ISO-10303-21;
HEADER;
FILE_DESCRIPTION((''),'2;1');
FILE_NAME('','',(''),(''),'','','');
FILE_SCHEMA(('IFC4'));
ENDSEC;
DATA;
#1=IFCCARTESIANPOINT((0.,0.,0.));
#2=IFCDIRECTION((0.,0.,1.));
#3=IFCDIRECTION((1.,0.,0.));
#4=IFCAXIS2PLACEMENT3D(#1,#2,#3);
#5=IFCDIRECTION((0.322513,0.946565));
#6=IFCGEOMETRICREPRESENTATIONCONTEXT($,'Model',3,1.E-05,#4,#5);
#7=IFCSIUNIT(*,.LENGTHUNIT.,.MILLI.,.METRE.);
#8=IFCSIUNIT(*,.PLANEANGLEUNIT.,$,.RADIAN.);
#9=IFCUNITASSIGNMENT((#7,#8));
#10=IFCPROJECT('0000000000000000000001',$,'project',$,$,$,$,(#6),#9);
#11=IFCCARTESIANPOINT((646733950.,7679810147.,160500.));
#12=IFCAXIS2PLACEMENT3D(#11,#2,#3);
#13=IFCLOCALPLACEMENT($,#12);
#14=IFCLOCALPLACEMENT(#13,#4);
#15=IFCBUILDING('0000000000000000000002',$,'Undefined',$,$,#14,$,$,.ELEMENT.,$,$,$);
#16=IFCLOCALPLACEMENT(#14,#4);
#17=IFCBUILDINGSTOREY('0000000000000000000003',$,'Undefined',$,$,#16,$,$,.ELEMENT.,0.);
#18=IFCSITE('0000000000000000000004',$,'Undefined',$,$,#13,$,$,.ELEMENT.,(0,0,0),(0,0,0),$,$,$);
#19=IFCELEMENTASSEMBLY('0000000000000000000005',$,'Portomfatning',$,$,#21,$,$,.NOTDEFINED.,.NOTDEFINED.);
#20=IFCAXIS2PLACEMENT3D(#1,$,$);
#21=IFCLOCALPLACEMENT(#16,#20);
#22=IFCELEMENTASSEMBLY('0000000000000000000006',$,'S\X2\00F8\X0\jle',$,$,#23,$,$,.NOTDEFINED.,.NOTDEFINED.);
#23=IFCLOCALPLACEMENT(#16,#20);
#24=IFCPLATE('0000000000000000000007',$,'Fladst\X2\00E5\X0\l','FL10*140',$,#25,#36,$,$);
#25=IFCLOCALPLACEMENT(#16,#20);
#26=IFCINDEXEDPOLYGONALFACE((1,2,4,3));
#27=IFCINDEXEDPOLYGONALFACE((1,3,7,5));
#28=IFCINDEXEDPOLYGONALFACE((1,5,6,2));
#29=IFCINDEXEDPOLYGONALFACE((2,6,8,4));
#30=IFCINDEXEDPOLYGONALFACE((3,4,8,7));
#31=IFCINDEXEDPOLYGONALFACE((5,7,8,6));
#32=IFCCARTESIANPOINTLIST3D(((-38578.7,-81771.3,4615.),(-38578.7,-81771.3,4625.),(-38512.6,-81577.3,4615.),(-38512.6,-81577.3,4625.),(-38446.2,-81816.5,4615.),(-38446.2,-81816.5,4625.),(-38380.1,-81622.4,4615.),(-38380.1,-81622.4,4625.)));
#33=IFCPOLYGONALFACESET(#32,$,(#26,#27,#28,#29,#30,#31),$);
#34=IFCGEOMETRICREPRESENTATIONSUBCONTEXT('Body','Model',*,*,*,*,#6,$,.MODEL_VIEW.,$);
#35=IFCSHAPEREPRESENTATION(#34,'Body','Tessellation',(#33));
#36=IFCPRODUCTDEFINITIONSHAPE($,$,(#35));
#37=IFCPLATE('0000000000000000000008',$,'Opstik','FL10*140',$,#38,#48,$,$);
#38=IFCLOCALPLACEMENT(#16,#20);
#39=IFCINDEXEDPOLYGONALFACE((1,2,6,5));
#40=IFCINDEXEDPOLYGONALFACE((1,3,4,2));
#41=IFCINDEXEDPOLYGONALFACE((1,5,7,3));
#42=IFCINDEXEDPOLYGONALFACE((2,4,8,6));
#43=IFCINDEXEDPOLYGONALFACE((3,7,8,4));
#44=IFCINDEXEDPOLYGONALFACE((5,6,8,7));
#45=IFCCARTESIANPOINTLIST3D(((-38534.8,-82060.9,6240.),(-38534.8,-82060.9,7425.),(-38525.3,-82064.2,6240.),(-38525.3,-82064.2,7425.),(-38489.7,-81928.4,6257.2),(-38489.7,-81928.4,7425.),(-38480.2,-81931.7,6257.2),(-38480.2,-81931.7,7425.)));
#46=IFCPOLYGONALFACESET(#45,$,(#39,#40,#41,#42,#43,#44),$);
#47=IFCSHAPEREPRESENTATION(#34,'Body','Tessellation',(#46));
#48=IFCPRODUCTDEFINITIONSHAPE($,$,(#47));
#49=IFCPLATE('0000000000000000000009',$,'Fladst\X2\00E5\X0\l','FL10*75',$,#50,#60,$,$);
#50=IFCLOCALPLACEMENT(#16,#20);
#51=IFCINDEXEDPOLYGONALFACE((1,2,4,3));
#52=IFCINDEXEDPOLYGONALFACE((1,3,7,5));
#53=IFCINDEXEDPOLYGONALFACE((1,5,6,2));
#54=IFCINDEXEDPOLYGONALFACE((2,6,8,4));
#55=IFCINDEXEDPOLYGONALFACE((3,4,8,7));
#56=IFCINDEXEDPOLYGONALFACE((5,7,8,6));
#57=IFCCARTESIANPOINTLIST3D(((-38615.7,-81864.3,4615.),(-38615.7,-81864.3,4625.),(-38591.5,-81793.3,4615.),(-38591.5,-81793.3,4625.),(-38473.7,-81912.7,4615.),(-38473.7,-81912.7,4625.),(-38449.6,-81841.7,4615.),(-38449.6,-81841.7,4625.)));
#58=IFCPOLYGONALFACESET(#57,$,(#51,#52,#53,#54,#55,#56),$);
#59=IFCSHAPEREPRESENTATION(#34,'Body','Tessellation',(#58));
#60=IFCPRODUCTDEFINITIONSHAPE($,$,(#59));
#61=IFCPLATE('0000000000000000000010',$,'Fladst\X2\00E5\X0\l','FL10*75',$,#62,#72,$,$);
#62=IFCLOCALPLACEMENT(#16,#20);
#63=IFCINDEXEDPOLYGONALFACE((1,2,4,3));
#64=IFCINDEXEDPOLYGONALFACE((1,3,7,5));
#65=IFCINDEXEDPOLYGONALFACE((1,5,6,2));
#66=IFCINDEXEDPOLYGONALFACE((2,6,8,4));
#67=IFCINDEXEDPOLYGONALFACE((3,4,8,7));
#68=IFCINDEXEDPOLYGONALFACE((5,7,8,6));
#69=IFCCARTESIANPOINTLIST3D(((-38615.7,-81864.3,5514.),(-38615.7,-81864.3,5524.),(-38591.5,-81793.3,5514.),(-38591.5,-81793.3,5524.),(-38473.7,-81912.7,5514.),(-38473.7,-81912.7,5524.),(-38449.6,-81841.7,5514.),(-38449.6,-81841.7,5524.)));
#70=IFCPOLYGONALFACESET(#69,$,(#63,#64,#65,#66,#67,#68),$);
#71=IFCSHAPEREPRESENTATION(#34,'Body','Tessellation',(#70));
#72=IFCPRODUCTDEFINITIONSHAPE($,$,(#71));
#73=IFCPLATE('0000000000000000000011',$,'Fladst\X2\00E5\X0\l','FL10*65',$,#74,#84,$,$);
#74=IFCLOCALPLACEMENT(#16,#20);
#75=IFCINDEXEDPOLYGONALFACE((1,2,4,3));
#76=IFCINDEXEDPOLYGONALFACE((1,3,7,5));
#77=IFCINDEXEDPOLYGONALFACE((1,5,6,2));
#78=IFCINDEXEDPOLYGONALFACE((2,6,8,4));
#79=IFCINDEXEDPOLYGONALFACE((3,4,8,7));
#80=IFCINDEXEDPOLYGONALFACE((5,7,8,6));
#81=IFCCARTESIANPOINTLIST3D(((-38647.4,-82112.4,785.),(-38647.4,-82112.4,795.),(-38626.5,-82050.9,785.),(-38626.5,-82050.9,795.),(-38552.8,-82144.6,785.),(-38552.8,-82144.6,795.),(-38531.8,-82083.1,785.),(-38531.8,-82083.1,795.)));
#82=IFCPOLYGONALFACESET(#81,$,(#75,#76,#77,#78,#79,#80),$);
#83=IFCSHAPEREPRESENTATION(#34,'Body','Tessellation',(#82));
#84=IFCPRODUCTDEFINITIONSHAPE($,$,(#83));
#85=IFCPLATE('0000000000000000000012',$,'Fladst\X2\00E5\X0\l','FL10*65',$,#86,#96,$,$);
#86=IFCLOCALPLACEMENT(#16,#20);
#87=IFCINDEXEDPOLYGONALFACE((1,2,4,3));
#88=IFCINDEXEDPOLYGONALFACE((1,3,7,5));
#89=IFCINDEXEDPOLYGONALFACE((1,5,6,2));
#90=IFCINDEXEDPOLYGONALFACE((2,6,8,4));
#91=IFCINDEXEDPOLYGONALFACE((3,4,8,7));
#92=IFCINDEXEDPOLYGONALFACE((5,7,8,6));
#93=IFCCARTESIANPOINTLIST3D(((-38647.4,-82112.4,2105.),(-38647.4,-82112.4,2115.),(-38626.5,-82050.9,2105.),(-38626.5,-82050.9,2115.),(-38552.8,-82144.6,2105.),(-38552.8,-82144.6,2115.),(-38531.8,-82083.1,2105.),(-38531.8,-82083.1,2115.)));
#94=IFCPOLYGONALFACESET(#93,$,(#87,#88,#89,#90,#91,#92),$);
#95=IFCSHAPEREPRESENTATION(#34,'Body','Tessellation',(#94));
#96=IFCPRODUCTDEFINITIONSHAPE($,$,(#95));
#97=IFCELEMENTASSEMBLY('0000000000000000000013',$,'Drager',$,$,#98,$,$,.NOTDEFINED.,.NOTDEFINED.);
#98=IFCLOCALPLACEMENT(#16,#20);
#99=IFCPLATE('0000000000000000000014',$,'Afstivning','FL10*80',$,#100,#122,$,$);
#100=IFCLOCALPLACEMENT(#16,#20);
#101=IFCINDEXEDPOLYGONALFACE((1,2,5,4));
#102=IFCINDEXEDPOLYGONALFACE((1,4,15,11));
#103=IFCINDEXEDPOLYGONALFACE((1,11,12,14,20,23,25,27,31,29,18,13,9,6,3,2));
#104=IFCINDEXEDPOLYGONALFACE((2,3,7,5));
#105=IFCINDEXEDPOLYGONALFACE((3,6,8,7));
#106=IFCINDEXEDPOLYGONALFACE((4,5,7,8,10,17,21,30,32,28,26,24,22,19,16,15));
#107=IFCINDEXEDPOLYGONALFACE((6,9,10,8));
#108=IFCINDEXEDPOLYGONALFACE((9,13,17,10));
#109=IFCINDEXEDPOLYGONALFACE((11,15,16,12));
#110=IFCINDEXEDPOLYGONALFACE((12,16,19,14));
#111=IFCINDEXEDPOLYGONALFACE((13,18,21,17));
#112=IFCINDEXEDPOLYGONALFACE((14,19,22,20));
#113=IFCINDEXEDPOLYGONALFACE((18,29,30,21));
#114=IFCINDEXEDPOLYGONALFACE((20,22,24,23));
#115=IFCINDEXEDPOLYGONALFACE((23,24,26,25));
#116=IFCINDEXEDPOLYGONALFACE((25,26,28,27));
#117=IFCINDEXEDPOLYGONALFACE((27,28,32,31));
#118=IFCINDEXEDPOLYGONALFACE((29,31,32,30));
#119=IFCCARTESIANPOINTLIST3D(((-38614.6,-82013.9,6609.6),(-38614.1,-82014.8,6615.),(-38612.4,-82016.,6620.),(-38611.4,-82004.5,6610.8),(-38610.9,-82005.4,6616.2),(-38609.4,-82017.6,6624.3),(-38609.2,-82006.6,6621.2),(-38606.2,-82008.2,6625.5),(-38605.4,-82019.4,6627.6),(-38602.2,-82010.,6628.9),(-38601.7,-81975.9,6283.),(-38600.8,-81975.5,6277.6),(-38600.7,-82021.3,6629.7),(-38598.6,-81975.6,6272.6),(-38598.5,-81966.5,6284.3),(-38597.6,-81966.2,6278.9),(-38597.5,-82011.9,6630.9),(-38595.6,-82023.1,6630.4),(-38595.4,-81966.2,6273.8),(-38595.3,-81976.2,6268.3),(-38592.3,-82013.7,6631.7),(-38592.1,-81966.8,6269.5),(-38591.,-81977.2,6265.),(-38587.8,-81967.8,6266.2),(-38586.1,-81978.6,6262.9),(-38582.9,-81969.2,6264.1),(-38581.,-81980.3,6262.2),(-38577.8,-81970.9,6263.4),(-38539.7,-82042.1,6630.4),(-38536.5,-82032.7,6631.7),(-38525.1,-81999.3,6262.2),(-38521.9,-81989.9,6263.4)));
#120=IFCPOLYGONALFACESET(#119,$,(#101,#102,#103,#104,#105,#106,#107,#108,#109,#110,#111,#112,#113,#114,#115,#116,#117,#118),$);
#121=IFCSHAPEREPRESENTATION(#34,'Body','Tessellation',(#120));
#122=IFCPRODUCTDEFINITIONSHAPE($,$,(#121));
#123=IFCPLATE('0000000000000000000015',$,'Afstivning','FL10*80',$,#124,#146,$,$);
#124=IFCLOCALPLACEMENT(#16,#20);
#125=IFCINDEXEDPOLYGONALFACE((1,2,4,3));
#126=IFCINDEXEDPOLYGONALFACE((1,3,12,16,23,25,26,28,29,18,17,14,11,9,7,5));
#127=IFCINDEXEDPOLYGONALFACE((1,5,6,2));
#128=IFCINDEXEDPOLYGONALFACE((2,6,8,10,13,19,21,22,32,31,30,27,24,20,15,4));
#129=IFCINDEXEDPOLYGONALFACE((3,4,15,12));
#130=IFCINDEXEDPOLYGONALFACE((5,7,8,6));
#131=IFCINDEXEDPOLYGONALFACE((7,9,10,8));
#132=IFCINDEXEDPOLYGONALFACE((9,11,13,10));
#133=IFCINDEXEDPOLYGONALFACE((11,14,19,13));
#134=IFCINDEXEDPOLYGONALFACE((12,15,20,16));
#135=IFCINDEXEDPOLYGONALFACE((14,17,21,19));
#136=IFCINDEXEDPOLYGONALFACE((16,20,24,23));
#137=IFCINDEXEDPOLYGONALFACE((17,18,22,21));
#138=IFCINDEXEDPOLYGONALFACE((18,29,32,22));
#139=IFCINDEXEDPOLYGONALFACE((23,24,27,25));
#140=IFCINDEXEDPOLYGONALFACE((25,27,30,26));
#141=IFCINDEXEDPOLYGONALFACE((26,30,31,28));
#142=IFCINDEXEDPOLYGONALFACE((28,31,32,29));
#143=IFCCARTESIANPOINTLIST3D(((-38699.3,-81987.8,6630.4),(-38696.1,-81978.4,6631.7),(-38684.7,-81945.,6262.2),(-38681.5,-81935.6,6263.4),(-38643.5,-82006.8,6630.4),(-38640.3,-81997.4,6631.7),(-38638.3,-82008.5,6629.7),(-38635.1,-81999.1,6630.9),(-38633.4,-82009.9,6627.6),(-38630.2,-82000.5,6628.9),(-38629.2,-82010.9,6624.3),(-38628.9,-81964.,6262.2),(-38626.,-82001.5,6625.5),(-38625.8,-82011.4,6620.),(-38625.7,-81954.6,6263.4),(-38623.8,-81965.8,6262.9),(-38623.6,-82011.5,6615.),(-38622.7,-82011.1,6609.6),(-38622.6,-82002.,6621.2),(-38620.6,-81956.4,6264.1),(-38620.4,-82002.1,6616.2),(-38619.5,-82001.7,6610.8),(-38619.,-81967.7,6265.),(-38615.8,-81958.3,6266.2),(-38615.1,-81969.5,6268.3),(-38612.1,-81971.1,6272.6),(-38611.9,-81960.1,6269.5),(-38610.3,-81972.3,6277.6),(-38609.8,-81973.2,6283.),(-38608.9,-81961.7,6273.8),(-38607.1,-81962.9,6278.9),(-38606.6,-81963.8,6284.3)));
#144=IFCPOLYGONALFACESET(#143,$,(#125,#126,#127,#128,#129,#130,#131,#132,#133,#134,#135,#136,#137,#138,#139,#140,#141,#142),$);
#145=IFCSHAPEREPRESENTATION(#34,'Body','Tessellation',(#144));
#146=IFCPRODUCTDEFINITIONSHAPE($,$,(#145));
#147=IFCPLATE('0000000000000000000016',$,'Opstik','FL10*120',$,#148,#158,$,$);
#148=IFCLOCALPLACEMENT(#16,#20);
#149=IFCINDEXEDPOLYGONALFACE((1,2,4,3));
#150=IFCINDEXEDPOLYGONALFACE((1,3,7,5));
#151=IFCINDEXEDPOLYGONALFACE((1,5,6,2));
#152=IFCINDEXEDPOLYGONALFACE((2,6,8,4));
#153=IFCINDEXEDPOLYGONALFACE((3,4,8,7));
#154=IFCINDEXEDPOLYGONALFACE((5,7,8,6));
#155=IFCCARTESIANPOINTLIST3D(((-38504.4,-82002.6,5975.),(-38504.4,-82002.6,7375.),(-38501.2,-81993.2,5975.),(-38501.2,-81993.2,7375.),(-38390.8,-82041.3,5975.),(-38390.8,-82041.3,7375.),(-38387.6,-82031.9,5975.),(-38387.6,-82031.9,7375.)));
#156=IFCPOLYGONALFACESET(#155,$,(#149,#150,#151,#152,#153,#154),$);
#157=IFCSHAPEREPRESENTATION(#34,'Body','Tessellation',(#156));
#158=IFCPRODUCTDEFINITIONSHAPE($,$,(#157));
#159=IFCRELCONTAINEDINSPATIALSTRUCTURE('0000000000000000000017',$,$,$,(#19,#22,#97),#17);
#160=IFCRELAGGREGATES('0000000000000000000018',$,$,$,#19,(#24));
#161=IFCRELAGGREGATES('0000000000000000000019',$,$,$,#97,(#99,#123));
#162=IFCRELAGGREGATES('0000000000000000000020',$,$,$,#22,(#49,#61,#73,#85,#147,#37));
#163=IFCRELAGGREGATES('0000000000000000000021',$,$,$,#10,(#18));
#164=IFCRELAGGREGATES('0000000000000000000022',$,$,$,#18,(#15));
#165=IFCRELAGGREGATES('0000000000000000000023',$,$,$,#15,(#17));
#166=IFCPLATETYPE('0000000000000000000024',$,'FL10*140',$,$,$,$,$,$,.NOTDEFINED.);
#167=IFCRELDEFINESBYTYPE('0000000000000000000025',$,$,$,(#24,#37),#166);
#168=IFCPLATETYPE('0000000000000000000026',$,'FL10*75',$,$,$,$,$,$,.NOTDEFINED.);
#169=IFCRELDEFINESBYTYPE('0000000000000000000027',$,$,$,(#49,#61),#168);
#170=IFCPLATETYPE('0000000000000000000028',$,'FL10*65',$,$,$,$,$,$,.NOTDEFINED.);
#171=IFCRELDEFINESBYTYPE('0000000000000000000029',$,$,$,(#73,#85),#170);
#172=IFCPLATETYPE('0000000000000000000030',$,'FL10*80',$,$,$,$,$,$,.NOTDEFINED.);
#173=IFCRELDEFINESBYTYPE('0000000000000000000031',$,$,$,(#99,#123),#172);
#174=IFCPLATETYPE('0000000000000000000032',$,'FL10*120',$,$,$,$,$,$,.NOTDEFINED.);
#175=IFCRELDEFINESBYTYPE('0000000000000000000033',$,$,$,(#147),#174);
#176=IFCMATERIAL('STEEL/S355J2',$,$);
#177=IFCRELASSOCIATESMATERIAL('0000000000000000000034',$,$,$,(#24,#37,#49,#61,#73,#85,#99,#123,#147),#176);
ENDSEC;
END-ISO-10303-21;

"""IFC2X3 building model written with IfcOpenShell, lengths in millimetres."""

from ifc_helpers import new_model, si_unit, direction, frame, frame_2d, origin_with_axes, place, context, subcontext, project, spatial, polyline, circle_curve, parameter, trimmed, segment, composite_curve, outline, extrude, material, type_object, element, aggregate, save


model = new_model("IFC2X3")

# Units and contexts
model_context = context("Model", 3, precision=1e-05, world=origin_with_axes(), true_north=direction((0.322513, 0.946565)))
body_context = subcontext(model_context, "Body", "Model", "MODEL_VIEW")
ifc_project = project(units=[si_unit("LENGTHUNIT", "METRE", prefix="MILLI"), si_unit("PLANEANGLEUNIT", "RADIAN")], contexts=[model_context])

# Site, building, storey
site_placement = place(None, frame((646733950.0, 7679810147.0, 160500.0), z_axis=(0.0, 0.0, 1.0), x_axis=(1.0, 0.0, 0.0)))
site = spatial("IfcSite", under=ifc_project, at=site_placement, Name="Undefined", CompositionType="ELEMENT", RefLatitude=(0, 0, 0), RefLongitude=(0, 0, 0))
building_placement = place(site_placement, origin_with_axes())
building = spatial("IfcBuilding", under=site, at=building_placement, Name="Undefined", CompositionType="ELEMENT")
storey_placement = place(building_placement, origin_with_axes())
storey = spatial("IfcBuildingStorey", under=building, at=storey_placement, Name="Undefined", CompositionType="ELEMENT", Elevation=0.0)

# Element assemblies
assembly_1_placement = place(storey_placement, origin_with_axes())
assembly_1 = element("IfcElementAssembly", 1, at=assembly_1_placement, inside=storey, Name="Portomfatning", AssemblyPlace="NOTDEFINED", PredefinedType="NOTDEFINED")
assembly_2_placement = place(storey_placement, origin_with_axes())
assembly_2 = element("IfcElementAssembly", 2, at=assembly_2_placement, inside=storey, Name="Søjle", AssemblyPlace="NOTDEFINED", PredefinedType="NOTDEFINED")

# Shared definitions
ifc_material_1 = material(Name="STEEL/S355J2")

# Plates
plate_type_1 = type_object("IfcPlateType", Name="FL10*140", PredefinedType="NOTDEFINED")
plate_1_placement = place(assembly_1_placement, frame((-38446.4, -81599.8, 4620.0), z_axis=(0.0, 0.0, -1.0), x_axis=(-0.322513, -0.946565, 0.0)))
plate_1 = element("IfcPlate", 3, at=plate_1_placement, type_object=plate_type_1, material=ifc_material_1, Name="Fladstål", Description="FL10*140", context=body_context, shape_type="SweptSolid", body=[
    extrude(outline(polyline([(0.0, -70.0), (0.0, 70.0), (205.0, 70.0), (205.0, -70.0), (0.0, -70.0)])), frame((0.0, 0.0, -5.0), z_axis=(0.0, 0.0, 1.0), x_axis=(1.0, 0.0, 0.0)), (0.0, 0.0, 1.0), 10.0),
])
plate_2_placement = place(assembly_2_placement, frame((-38484.9, -81930.0, 6257.2), z_axis=(0.946565, -0.322513, 0.0), x_axis=(0.0, 0.0, 1.0)))
plate_2 = element("IfcPlate", 4, at=plate_2_placement, type_object=plate_type_1, material=ifc_material_1, Name="Opstik", Description="FL10*140", context=body_context, shape_type="SweptSolid", body=[
    extrude(outline(polyline([(0.0, 0.0), (1167.8, 0.0), (1167.8, 0.0), (1167.8, 140.0), (1167.8, 140.0), (-17.2, 140.0), (0.0, 0.0)])), frame((0.0, 0.0, -5.0), z_axis=(0.0, 0.0, 1.0), x_axis=(1.0, 0.0, 0.0)), (0.0, 0.0, 1.0), 10.0),
])
plate_type_2 = type_object("IfcPlateType", Name="FL10*75", PredefinedType="NOTDEFINED")
plate_3_placement = place(assembly_2_placement, frame((-38615.7, -81864.3, 4620.0), z_axis=(0.0, 0.0, -1.0), x_axis=(0.322513, 0.946565, 0.0)))
plate_3 = element("IfcPlate", 5, at=plate_3_placement, type_object=plate_type_2, material=ifc_material_1, Name="Fladstål", Description="FL10*75", context=body_context, shape_type="SweptSolid", body=[
    extrude(outline(polyline([(0.0, 0.0), (75.0, 0.0), (75.0, 150.0), (0.0, 150.0), (0.0, 0.0)])), frame((0.0, 0.0, -5.0), z_axis=(0.0, 0.0, 1.0), x_axis=(1.0, 0.0, 0.0)), (0.0, 0.0, 1.0), 10.0),
])
plate_4_placement = place(assembly_2_placement, frame((-38615.7, -81864.3, 5519.0), z_axis=(0.0, 0.0, -1.0), x_axis=(0.322513, 0.946565, 0.0)))
plate_4 = element("IfcPlate", 6, at=plate_4_placement, type_object=plate_type_2, material=ifc_material_1, Name="Fladstål", Description="FL10*75", context=body_context, shape_type="SweptSolid", body=[
    extrude(outline(polyline([(0.0, 0.0), (75.0, 0.0), (75.0, 150.0), (0.0, 150.0), (0.0, 0.0)])), frame((0.0, 0.0, -5.0), z_axis=(0.0, 0.0, 1.0), x_axis=(1.0, 0.0, 0.0)), (0.0, 0.0, 1.0), 10.0),
])
plate_type_3 = type_object("IfcPlateType", Name="FL10*65", PredefinedType="NOTDEFINED")
plate_5_placement = place(assembly_2_placement, frame((-38626.5, -82050.9, 790.0), z_axis=(0.0, 0.0, 1.0), x_axis=(-0.322513, -0.946565, 0.0)))
plate_5 = element("IfcPlate", 7, at=plate_5_placement, type_object=plate_type_3, material=ifc_material_1, Name="Fladstål", Description="FL10*65", context=body_context, shape_type="SweptSolid", body=[
    extrude(outline(polyline([(0.0, 0.0), (65.0, 0.0), (65.0, 100.0), (0.0, 100.0), (0.0, 0.0)])), frame((0.0, 0.0, -5.0), z_axis=(0.0, 0.0, 1.0), x_axis=(1.0, 0.0, 0.0)), (0.0, 0.0, 1.0), 10.0),
])
plate_6_placement = place(assembly_2_placement, frame((-38626.5, -82050.9, 2110.0), z_axis=(0.0, 0.0, 1.0), x_axis=(-0.322513, -0.946565, 0.0)))
plate_6 = element("IfcPlate", 8, at=plate_6_placement, type_object=plate_type_3, material=ifc_material_1, Name="Fladstål", Description="FL10*65", context=body_context, shape_type="SweptSolid", body=[
    extrude(outline(polyline([(0.0, 0.0), (65.0, 0.0), (65.0, 100.0), (0.0, 100.0), (0.0, 0.0)])), frame((0.0, 0.0, -5.0), z_axis=(0.0, 0.0, 1.0), x_axis=(1.0, 0.0, 0.0)), (0.0, 0.0, 1.0), 10.0),
])

# Element assembly, plates
assembly_3_placement = place(storey_placement, origin_with_axes())
assembly_3 = element("IfcElementAssembly", 9, at=assembly_3_placement, inside=storey, Name="Drager", AssemblyPlace="NOTDEFINED", PredefinedType="NOTDEFINED")
plate_type_4 = type_object("IfcPlateType", Name="FL10*80", PredefinedType="NOTDEFINED")
plate_7_placement = place(assembly_3_placement, frame((-38599.2, -81968.8, 6262.8), z_axis=(-0.320109, -0.93951, -0.121869), x_axis=(0.946565, -0.322513, 0.0)))
plate_7 = element("IfcPlate", 10, at=plate_7_placement, type_object=plate_type_4, material=ifc_material_1, Name="Afstivning", Description="FL10*80", context=body_context, shape_type="SweptSolid", body=[
    extrude(outline(composite_curve([segment(trimmed(circle_curve(frame_2d((21.0, 21.0), x_axis=(-1.0, 0.0)), 21.0), [parameter(0.0)], [parameter(1.570796)], True, "PARAMETER"), True, "CONTINUOUS"), segment(polyline([(21.0, 0.0), (80.0, 0.0), (80.0, 371.0), (21.0, 371.0)]), True, "CONTINUOUS"), segment(trimmed(circle_curve(frame_2d((21.0, 350.0), x_axis=(0.0, 1.0)), 21.0), [parameter(0.0)], [parameter(1.570796)], True, "PARAMETER"), True, "CONTINUOUS"), segment(polyline([(0.0, 350.0), (0.0, 21.0)]), True, "CONTINUOUS")], self_intersect=True)), frame((0.0, 0.0, -5.0), z_axis=(0.0, 0.0, 1.0), x_axis=(1.0, 0.0, 0.0)), (0.0, 0.0, 1.0), 10.0),
])
plate_8_placement = place(assembly_3_placement, frame((-38683.1, -81940.3, 6262.8), z_axis=(-0.320109, -0.93951, -0.121869), x_axis=(0.946565, -0.322513, 0.0)))
plate_8 = element("IfcPlate", 11, at=plate_8_placement, type_object=plate_type_4, material=ifc_material_1, Name="Afstivning", Description="FL10*80", context=body_context, shape_type="SweptSolid", body=[
    extrude(outline(composite_curve([segment(polyline([(0.0, 0.0), (59.0, 0.0)]), True, "CONTINUOUS"), segment(trimmed(circle_curve(frame_2d((59.0, 21.0), x_axis=(0.0, -1.0)), 21.0), [parameter(0.0)], [parameter(1.570796)], True, "PARAMETER"), True, "CONTINUOUS"), segment(polyline([(80.0, 21.0), (80.0, 350.0)]), True, "CONTINUOUS"), segment(trimmed(circle_curve(frame_2d((59.0, 350.0), x_axis=(1.0, 0.0)), 21.0), [parameter(0.0)], [parameter(1.570796)], True, "PARAMETER"), True, "CONTINUOUS"), segment(polyline([(59.0, 371.0), (0.0, 371.0), (0.0, 0.0)]), True, "CONTINUOUS")], self_intersect=True)), frame((0.0, 0.0, -5.0), z_axis=(0.0, 0.0, 1.0), x_axis=(1.0, 0.0, 0.0)), (0.0, 0.0, 1.0), 10.0),
])

# Plate
plate_type_5 = type_object("IfcPlateType", Name="FL10*120", PredefinedType="NOTDEFINED")
plate_9_placement = place(assembly_2_placement, frame((-38502.8, -81997.9, 5975.0), z_axis=(0.322513, 0.946565, 0.0), x_axis=(0.0, 0.0, 1.0)))
plate_9 = element("IfcPlate", 12, at=plate_9_placement, type_object=plate_type_5, material=ifc_material_1, Name="Opstik", Description="FL10*120", context=body_context, shape_type="SweptSolid", body=[
    extrude(outline(polyline([(0.0, 0.0), (1400.0, 0.0), (1400.0, 120.0), (1400.0, 120.0), (0.0, 120.0), (0.0, 120.0), (0.0, 0.0)])), frame((0.0, 0.0, -5.0), z_axis=(0.0, 0.0, 1.0), x_axis=(1.0, 0.0, 0.0)), (0.0, 0.0, 1.0), 10.0),
])

aggregate(assembly_1, [plate_1])
aggregate(assembly_3, [plate_7, plate_8])
aggregate(assembly_2, [plate_3, plate_4, plate_5, plate_6, plate_9, plate_2])

save(model, "model.ifc")
